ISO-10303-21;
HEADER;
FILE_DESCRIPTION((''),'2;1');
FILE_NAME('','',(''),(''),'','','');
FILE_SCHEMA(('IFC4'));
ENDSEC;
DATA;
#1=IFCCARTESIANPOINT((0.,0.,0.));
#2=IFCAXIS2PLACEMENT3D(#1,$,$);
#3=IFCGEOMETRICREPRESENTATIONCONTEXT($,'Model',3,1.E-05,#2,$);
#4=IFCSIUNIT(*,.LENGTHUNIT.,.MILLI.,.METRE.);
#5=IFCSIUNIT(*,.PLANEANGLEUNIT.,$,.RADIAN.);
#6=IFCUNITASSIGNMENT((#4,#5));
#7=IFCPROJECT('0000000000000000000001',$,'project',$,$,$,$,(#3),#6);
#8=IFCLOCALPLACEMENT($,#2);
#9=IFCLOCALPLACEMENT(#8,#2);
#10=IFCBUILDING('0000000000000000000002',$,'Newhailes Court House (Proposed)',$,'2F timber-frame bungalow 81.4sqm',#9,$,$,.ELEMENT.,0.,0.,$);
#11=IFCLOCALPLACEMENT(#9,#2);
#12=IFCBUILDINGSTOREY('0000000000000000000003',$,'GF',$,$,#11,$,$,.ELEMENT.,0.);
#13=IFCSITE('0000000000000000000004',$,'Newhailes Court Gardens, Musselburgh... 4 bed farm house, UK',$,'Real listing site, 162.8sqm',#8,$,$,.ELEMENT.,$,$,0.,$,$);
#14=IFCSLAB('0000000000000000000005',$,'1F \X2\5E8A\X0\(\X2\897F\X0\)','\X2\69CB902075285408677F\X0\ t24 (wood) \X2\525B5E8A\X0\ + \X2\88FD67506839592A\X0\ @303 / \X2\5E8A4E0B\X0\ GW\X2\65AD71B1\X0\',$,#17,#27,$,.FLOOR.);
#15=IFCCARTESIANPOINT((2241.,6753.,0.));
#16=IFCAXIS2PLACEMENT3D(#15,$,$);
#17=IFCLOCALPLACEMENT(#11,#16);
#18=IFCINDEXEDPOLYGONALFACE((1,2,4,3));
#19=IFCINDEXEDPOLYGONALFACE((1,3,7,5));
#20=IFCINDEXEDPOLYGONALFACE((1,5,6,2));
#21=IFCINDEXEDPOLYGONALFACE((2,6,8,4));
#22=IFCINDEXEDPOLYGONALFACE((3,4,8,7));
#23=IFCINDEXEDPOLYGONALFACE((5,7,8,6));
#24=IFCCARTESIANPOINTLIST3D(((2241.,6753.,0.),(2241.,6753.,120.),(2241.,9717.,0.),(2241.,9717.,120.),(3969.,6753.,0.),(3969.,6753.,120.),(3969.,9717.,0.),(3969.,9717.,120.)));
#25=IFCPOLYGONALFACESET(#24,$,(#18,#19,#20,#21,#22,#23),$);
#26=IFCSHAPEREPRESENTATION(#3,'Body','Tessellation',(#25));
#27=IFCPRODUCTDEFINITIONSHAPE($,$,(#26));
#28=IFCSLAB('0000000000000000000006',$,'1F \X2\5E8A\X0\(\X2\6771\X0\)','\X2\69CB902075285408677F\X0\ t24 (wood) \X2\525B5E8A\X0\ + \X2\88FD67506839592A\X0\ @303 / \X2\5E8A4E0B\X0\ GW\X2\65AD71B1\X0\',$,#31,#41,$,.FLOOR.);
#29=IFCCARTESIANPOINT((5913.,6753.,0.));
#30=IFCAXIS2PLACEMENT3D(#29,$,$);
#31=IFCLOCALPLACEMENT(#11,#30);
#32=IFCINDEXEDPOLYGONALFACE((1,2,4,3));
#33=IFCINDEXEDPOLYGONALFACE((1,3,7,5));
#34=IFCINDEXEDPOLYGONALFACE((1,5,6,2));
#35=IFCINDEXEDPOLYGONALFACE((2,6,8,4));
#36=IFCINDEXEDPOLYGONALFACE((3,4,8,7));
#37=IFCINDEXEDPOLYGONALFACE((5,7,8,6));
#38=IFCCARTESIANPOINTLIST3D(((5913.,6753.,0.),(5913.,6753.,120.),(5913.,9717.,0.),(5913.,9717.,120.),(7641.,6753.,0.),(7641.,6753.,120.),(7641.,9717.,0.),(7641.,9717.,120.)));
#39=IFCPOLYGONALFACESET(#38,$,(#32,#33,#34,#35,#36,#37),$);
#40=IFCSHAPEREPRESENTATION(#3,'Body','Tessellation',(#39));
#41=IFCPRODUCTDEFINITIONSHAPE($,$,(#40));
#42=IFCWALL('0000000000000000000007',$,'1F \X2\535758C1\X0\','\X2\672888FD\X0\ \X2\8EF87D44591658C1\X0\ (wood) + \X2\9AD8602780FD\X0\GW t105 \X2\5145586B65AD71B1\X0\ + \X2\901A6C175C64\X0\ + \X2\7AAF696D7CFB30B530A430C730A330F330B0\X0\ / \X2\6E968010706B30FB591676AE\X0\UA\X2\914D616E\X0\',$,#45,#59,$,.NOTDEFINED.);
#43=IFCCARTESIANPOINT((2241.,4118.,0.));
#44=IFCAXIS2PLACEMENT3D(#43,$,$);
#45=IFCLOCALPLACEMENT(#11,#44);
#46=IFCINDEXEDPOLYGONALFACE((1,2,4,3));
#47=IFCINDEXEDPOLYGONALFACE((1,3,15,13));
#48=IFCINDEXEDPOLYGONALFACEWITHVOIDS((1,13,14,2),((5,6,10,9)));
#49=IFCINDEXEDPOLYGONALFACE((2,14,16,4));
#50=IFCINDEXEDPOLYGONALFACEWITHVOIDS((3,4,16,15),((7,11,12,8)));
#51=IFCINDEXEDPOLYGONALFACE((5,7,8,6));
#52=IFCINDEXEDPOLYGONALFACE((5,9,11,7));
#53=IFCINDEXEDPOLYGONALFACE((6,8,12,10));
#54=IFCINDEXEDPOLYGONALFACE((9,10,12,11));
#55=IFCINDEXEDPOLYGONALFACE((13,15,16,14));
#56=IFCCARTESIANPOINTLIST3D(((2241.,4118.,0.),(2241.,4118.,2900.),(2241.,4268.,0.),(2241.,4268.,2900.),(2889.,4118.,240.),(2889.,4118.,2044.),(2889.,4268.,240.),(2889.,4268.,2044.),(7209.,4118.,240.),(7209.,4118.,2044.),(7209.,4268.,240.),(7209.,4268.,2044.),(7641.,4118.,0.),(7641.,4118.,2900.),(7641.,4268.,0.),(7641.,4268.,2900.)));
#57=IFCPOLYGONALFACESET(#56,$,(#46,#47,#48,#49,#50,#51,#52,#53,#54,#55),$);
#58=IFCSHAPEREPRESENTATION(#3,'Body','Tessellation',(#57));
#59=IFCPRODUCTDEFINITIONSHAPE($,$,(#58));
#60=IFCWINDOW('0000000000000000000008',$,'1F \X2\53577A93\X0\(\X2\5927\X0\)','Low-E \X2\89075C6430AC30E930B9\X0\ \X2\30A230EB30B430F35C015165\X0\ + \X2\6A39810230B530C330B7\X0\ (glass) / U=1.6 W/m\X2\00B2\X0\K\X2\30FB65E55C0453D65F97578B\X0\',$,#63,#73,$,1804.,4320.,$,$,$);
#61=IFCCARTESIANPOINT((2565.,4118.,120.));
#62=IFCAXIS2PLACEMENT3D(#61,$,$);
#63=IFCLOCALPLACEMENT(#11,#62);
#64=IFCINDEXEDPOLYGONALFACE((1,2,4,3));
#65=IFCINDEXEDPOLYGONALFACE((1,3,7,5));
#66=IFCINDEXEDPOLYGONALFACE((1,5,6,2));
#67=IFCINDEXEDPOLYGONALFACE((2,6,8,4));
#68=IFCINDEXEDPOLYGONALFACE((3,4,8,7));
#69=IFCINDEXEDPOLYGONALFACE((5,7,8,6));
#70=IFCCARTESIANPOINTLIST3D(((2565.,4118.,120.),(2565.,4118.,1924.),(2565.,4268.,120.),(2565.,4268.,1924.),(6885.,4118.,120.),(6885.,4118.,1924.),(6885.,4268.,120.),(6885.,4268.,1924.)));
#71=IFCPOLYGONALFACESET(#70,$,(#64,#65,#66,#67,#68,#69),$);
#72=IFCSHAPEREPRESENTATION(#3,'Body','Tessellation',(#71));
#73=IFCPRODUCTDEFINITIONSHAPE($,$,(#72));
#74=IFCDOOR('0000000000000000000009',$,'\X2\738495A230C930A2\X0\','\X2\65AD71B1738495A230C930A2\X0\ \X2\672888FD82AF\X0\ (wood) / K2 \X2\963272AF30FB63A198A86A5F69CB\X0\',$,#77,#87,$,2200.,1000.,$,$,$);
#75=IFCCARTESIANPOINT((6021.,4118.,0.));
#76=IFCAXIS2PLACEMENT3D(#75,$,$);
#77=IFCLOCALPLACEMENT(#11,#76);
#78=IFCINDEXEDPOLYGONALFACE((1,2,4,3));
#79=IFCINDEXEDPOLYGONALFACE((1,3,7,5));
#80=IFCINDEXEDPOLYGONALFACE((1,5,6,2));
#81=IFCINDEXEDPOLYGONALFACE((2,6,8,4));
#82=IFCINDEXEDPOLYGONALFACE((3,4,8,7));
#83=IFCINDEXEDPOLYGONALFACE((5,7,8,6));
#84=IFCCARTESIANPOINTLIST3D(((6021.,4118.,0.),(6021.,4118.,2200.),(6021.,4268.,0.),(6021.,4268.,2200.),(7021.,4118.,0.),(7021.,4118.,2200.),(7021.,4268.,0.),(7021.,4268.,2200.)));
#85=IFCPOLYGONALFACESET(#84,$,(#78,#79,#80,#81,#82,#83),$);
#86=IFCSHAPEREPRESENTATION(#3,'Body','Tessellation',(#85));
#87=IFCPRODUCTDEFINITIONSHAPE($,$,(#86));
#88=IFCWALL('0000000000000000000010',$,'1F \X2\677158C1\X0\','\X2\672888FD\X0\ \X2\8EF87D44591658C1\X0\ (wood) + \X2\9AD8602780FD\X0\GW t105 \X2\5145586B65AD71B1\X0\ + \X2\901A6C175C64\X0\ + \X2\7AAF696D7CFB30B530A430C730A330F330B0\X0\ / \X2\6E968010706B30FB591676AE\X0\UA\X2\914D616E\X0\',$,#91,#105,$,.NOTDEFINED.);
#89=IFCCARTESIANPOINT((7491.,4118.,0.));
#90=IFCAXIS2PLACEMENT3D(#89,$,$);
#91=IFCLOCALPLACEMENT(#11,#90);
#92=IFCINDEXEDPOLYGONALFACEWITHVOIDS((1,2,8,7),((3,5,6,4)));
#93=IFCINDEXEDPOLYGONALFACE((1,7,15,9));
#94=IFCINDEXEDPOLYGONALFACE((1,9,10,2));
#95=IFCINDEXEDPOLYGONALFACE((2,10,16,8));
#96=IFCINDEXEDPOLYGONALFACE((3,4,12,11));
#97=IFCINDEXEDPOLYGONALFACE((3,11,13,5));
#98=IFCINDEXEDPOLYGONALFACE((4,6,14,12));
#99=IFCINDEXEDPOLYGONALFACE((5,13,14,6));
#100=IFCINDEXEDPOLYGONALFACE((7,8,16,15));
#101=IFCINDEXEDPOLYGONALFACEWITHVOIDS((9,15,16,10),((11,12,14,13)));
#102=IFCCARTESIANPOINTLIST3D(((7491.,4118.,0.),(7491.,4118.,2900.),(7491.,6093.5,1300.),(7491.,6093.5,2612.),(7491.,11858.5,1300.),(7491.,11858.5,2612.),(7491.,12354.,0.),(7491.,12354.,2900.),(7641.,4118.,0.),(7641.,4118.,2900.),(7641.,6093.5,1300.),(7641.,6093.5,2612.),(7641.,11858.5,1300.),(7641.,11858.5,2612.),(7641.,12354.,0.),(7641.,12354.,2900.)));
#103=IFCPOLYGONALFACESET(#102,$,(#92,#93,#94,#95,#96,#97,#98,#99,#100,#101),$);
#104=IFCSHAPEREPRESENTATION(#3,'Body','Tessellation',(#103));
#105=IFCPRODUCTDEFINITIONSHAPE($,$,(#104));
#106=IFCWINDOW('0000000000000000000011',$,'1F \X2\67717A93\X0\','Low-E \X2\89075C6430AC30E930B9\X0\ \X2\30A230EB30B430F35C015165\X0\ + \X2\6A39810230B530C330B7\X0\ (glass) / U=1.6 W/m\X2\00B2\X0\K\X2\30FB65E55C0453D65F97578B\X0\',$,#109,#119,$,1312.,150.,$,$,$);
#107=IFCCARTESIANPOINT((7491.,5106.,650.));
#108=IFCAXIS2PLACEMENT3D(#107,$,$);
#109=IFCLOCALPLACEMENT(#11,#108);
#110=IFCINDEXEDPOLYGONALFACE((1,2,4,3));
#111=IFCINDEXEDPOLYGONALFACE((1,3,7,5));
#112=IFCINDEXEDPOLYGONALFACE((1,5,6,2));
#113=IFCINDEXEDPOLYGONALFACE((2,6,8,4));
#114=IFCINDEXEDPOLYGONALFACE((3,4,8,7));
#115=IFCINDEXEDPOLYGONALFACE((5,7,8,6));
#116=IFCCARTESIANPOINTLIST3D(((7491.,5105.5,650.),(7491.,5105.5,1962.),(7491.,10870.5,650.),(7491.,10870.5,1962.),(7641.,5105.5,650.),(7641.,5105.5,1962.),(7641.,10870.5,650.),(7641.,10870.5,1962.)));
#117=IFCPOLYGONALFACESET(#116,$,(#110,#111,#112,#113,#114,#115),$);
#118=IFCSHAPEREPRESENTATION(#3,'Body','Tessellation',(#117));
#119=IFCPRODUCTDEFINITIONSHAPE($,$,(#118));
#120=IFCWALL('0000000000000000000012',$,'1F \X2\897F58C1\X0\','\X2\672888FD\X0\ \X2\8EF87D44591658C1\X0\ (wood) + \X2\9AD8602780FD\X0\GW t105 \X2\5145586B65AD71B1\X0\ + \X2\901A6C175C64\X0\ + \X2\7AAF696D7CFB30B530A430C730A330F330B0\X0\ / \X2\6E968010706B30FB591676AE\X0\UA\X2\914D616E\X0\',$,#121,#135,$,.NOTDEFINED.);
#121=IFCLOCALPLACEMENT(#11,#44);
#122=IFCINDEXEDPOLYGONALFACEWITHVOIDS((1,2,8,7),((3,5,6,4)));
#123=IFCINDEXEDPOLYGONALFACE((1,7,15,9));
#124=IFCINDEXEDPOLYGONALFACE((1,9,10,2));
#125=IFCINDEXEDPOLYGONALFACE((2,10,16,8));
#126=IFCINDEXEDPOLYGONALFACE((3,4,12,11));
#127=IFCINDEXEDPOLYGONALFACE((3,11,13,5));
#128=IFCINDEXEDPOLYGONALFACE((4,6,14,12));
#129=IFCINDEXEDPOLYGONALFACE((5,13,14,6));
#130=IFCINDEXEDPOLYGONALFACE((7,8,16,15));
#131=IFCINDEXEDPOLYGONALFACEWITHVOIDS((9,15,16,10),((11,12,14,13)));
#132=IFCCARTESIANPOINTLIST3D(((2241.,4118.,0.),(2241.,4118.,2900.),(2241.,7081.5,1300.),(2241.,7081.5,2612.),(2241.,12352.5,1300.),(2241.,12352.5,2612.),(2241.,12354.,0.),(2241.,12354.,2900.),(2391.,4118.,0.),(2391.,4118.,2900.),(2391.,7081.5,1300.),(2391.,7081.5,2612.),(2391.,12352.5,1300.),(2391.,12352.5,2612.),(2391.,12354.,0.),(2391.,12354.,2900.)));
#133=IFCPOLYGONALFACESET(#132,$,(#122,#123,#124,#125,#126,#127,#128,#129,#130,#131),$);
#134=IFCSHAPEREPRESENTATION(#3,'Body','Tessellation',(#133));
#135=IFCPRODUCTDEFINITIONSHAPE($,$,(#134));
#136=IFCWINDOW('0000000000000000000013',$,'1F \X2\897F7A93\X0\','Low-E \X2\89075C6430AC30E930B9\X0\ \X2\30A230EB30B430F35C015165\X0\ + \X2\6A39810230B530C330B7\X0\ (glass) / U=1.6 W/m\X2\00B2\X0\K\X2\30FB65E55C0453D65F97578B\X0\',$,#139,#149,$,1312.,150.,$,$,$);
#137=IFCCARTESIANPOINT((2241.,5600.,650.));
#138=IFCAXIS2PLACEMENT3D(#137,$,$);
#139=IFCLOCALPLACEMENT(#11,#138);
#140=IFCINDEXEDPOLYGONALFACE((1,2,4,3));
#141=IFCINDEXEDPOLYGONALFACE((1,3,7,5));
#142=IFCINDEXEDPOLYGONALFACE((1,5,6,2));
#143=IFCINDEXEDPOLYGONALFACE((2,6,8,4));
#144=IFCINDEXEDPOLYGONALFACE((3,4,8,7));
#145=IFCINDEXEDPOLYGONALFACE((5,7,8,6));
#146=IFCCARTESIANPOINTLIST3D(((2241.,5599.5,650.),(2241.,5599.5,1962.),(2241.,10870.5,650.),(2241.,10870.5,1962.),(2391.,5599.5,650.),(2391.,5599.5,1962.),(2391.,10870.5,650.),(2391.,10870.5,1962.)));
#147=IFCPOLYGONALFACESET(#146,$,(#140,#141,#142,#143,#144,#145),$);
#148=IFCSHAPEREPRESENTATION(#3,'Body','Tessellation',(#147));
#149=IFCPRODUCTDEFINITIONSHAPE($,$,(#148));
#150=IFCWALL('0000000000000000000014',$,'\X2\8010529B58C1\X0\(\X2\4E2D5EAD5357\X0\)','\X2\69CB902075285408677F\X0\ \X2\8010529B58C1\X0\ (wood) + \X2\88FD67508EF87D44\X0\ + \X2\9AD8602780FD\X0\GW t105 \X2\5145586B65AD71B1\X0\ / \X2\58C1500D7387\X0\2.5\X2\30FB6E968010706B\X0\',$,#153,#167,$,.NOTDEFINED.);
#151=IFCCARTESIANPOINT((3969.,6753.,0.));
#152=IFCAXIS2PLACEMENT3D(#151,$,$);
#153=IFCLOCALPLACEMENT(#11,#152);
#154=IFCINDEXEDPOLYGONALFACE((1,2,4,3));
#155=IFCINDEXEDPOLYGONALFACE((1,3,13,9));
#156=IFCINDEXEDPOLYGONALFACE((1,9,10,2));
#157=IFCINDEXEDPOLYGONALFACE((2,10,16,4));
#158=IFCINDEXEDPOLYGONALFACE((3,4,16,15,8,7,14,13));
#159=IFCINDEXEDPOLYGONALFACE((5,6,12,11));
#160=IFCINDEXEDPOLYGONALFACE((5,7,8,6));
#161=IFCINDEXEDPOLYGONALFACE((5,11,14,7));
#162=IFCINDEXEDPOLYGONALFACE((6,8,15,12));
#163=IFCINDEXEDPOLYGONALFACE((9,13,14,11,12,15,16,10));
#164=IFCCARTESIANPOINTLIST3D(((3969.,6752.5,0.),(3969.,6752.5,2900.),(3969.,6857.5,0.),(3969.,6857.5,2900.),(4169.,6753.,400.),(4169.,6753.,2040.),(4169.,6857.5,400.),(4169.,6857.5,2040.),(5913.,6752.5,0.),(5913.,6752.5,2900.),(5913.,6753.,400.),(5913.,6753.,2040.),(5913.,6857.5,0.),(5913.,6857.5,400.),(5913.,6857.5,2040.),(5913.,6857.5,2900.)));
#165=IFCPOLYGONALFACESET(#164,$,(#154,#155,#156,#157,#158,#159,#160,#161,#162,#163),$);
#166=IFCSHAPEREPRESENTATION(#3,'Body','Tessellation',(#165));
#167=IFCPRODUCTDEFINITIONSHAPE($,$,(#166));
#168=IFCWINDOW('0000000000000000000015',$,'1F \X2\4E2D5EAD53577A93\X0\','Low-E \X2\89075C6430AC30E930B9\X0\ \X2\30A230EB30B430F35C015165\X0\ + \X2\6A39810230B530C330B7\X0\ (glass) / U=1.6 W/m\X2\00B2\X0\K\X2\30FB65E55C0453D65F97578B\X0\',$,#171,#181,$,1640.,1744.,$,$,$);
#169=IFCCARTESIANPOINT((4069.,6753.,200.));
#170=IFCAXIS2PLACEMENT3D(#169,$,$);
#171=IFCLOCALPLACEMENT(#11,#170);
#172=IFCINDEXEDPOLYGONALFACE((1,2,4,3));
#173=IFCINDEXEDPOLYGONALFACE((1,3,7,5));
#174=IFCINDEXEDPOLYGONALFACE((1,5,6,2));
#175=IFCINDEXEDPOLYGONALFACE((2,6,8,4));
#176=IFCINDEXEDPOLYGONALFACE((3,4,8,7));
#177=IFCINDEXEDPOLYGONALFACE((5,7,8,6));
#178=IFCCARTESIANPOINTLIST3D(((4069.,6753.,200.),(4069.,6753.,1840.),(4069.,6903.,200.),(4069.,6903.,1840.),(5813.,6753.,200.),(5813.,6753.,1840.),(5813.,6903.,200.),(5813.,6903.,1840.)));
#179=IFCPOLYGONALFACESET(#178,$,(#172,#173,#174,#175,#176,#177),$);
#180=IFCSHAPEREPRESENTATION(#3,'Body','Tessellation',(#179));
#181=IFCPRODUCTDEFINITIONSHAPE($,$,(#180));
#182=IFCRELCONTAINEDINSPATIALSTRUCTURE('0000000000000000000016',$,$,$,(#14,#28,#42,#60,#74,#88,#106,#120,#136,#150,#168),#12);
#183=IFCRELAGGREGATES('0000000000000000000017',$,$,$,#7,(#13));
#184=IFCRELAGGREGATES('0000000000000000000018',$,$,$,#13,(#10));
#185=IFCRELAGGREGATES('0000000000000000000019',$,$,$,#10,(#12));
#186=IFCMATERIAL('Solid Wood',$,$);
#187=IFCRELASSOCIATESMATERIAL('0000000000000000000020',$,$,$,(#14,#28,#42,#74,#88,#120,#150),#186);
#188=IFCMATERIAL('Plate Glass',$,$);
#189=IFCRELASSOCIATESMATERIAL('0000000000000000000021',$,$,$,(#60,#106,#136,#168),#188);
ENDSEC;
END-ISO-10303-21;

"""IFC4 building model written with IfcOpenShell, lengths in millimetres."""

from ifc_helpers import new_model, si_unit, frame, frame_2d, origin, place, context, project, spatial, rectangle, extrude, material, element, fill, save


model = new_model("IFC4")

# Units and contexts
model_context = context("Model", 3, precision=1e-05, world=origin())
ifc_project = project(units=[si_unit("LENGTHUNIT", "METRE", prefix="MILLI"), si_unit("PLANEANGLEUNIT", "RADIAN")], contexts=[model_context])

# Site, building, storey
site_placement = place(None, origin())
site = spatial("IfcSite", under=ifc_project, at=site_placement, Name="Newhailes Court Gardens, Musselburgh... 4 bed farm house, UK", ObjectType="Real listing site, 162.8sqm", CompositionType="ELEMENT", RefElevation=0.0)
building_placement = place(site_placement, origin())
building = spatial("IfcBuilding", under=site, at=building_placement, Name="Newhailes Court House (Proposed)", ObjectType="2F timber-frame bungalow 81.4sqm", CompositionType="ELEMENT", ElevationOfRefHeight=0.0, ElevationOfTerrain=0.0)
storey_placement = place(building_placement, origin())
storey = spatial("IfcBuildingStorey", under=building, at=storey_placement, Name="GF", CompositionType="ELEMENT", Elevation=0.0)

# Slabs
ifc_material_1 = material(Name="Solid Wood")
slab_1_placement = place(storey_placement, frame((2241.0, 6753.0, 0.0)))
element("IfcSlab", 1, at=slab_1_placement, inside=storey, material=ifc_material_1, Name="1F 床(西)", Description="構造用合板 t24 (wood) 剛床 + 製材根太 @303 / 床下 GW断熱", PredefinedType="FLOOR", context=model_context, shape_type="SweptSolid", body=[
    extrude(rectangle(XDim=1728.0, YDim=2964.0, at=frame_2d((864.0, 1482.0))), frame((2241.0, 6753.0, 0.0)), (0.0, 0.0, 1.0), 120.0),
])
slab_2_placement = place(storey_placement, frame((5913.0, 6753.0, 0.0)))
element("IfcSlab", 2, at=slab_2_placement, inside=storey, material=ifc_material_1, Name="1F 床(東)", Description="構造用合板 t24 (wood) 剛床 + 製材根太 @303 / 床下 GW断熱", PredefinedType="FLOOR", context=model_context, shape_type="SweptSolid", body=[
    extrude(rectangle(XDim=1728.0, YDim=2964.0, at=frame_2d((864.0, 1482.0))), frame((5913.0, 6753.0, 0.0)), (0.0, 0.0, 1.0), 120.0),
])

# Wall, openings, window, door
wall_1_placement = place(storey_placement, frame((2241.0, 4118.0, 0.0)))
wall_1 = element("IfcWall", 3, at=wall_1_placement, inside=storey, material=ifc_material_1, Name="1F 南壁", Description="木製 軸組外壁 (wood) + 高性能GW t105 充填断熱 + 通気層 + 窯業系サイディング / 準耐火・外皮UA配慮", PredefinedType="NOTDEFINED", context=model_context, shape_type="SweptSolid", body=[
    extrude(rectangle(XDim=5400.0, YDim=150.0, at=frame_2d((2700.0, 75.0))), frame((2241.0, 4118.0, 0.0)), (0.0, 0.0, 1.0), 2900.0),
])
opening_1_placement = place(storey_placement, frame((2565.0, 4118.0, 120.0)))
opening_1 = element("IfcOpeningElement", 4, at=opening_1_placement, cuts=wall_1, PredefinedType="NOTDEFINED", context=model_context, shape_type="SweptSolid", body=[
    extrude(rectangle(XDim=4320.0, YDim=150.0, at=frame_2d((2160.0, 75.0))), frame((2565.0, 4118.0, 120.0)), (0.0, 0.0, 1.0), 1804.0),
])
opening_2_placement = place(storey_placement, frame((6021.0, 4118.0, 0.0)))
opening_2 = element("IfcOpeningElement", 5, at=opening_2_placement, cuts=wall_1, PredefinedType="NOTDEFINED", context=model_context, shape_type="SweptSolid", body=[
    extrude(rectangle(XDim=1000.0, YDim=150.0, at=frame_2d((500.0, 75.0))), frame((6021.0, 4118.0, 0.0)), (0.0, 0.0, 1.0), 2200.0),
])
ifc_material_2 = material(Name="Plate Glass")
window_1_placement = place(storey_placement, frame((2565.0, 4118.0, 120.0)))
window_1 = element("IfcWindow", 6, at=window_1_placement, inside=storey, material=ifc_material_2, Name="1F 南窓(大)", Description="Low-E 複層ガラス アルゴン封入 + 樹脂サッシ (glass) / U=1.6 W/m²K・日射取得型", OverallHeight=1804.0, OverallWidth=4320.0, context=model_context, shape_type="SweptSolid", body=[
    extrude(rectangle(XDim=4320.0, YDim=150.0, at=frame_2d((2160.0, 75.0))), frame((2565.0, 4118.0, 120.0)), (0.0, 0.0, 1.0), 1804.0),
])
fill(opening_1, window_1)
door_placement = place(storey_placement, frame((6021.0, 4118.0, 0.0)))
door = element("IfcDoor", 7, at=door_placement, inside=storey, material=ifc_material_1, Name="玄関ドア", Description="断熱玄関ドア 木製芯 (wood) / K2 防犯・採風機構", OverallHeight=2200.0, OverallWidth=1000.0, context=model_context, shape_type="SweptSolid", body=[
    extrude(rectangle(XDim=1000.0, YDim=150.0, at=frame_2d((500.0, 75.0))), frame((6021.0, 4118.0, 0.0)), (0.0, 0.0, 1.0), 2200.0),
])
fill(opening_2, door)

# Walls, openings, windows
wall_2_placement = place(storey_placement, frame((7491.0, 4118.0, 0.0)))
wall_2 = element("IfcWall", 8, at=wall_2_placement, inside=storey, material=ifc_material_1, Name="1F 東壁", Description="木製 軸組外壁 (wood) + 高性能GW t105 充填断熱 + 通気層 + 窯業系サイディング / 準耐火・外皮UA配慮", PredefinedType="NOTDEFINED", context=model_context, shape_type="SweptSolid", body=[
    extrude(rectangle(XDim=150.0, YDim=8236.0, at=frame_2d((75.0, 4118.0))), frame((7491.0, 4118.0, 0.0)), (0.0, 0.0, 1.0), 2900.0),
])
opening_3_placement = place(storey_placement, frame((7491.0, 5106.0, 650.0)))
opening_3 = element("IfcOpeningElement", 9, at=opening_3_placement, cuts=wall_2, PredefinedType="NOTDEFINED", context=model_context, shape_type="SweptSolid", body=[
    extrude(rectangle(XDim=150.0, YDim=5765.0, at=frame_2d((75.0, 2882.0))), frame((7491.0, 5106.0, 650.0)), (0.0, 0.0, 1.0), 1312.0),
])
window_2_placement = place(storey_placement, frame((7491.0, 5106.0, 650.0)))
window_2 = element("IfcWindow", 10, at=window_2_placement, inside=storey, material=ifc_material_2, Name="1F 東窓", Description="Low-E 複層ガラス アルゴン封入 + 樹脂サッシ (glass) / U=1.6 W/m²K・日射取得型", OverallHeight=1312.0, OverallWidth=150.0, context=model_context, shape_type="SweptSolid", body=[
    extrude(rectangle(XDim=150.0, YDim=5765.0, at=frame_2d((75.0, 2882.0))), frame((7491.0, 5106.0, 650.0)), (0.0, 0.0, 1.0), 1312.0),
])
fill(opening_3, window_2)
wall_3_placement = place(storey_placement, frame((2241.0, 4118.0, 0.0)))
wall_3 = element("IfcWall", 11, at=wall_3_placement, inside=storey, material=ifc_material_1, Name="1F 西壁", Description="木製 軸組外壁 (wood) + 高性能GW t105 充填断熱 + 通気層 + 窯業系サイディング / 準耐火・外皮UA配慮", PredefinedType="NOTDEFINED", context=model_context, shape_type="SweptSolid", body=[
    extrude(rectangle(XDim=150.0, YDim=8236.0, at=frame_2d((75.0, 4118.0))), frame((2241.0, 4118.0, 0.0)), (0.0, 0.0, 1.0), 2900.0),
])
opening_4_placement = place(storey_placement, frame((2241.0, 5600.0, 650.0)))
opening_4 = element("IfcOpeningElement", 12, at=opening_4_placement, cuts=wall_3, PredefinedType="NOTDEFINED", context=model_context, shape_type="SweptSolid", body=[
    extrude(rectangle(XDim=150.0, YDim=5271.0, at=frame_2d((75.0, 2635.0))), frame((2241.0, 5600.0, 650.0)), (0.0, 0.0, 1.0), 1312.0),
])
window_3_placement = place(storey_placement, frame((2241.0, 5600.0, 650.0)))
window_3 = element("IfcWindow", 13, at=window_3_placement, inside=storey, material=ifc_material_2, Name="1F 西窓", Description="Low-E 複層ガラス アルゴン封入 + 樹脂サッシ (glass) / U=1.6 W/m²K・日射取得型", OverallHeight=1312.0, OverallWidth=150.0, context=model_context, shape_type="SweptSolid", body=[
    extrude(rectangle(XDim=150.0, YDim=5271.0, at=frame_2d((75.0, 2635.0))), frame((2241.0, 5600.0, 650.0)), (0.0, 0.0, 1.0), 1312.0),
])
fill(opening_4, window_3)
wall_4_placement = place(storey_placement, frame((3969.0, 6753.0, 0.0)))
wall_4 = element("IfcWall", 14, at=wall_4_placement, inside=storey, material=ifc_material_1, Name="耐力壁(中庭南)", Description="構造用合板 耐力壁 (wood) + 製材軸組 + 高性能GW t105 充填断熱 / 壁倍率2.5・準耐火", PredefinedType="NOTDEFINED", context=model_context, shape_type="SweptSolid", body=[
    extrude(rectangle(XDim=1944.0, YDim=105.0, at=frame_2d((972.0, 52.0))), frame((3969.0, 6753.0, 0.0)), (0.0, 0.0, 1.0), 2900.0),
])
opening_5_placement = place(storey_placement, frame((4069.0, 6753.0, 200.0)))
opening_5 = element("IfcOpeningElement", 15, at=opening_5_placement, cuts=wall_4, PredefinedType="NOTDEFINED", context=model_context, shape_type="SweptSolid", body=[
    extrude(rectangle(XDim=1744.0, YDim=150.0, at=frame_2d((872.0, 75.0))), frame((4069.0, 6753.0, 200.0)), (0.0, 0.0, 1.0), 1640.0),
])
window_4_placement = place(storey_placement, frame((4069.0, 6753.0, 200.0)))
window_4 = element("IfcWindow", 16, at=window_4_placement, inside=storey, material=ifc_material_2, Name="1F 中庭南窓", Description="Low-E 複層ガラス アルゴン封入 + 樹脂サッシ (glass) / U=1.6 W/m²K・日射取得型", OverallHeight=1640.0, OverallWidth=1744.0, context=model_context, shape_type="SweptSolid", body=[
    extrude(rectangle(XDim=1744.0, YDim=150.0, at=frame_2d((872.0, 75.0))), frame((4069.0, 6753.0, 200.0)), (0.0, 0.0, 1.0), 1640.0),
])
fill(opening_5, window_4)

save(model, "model.ifc")
